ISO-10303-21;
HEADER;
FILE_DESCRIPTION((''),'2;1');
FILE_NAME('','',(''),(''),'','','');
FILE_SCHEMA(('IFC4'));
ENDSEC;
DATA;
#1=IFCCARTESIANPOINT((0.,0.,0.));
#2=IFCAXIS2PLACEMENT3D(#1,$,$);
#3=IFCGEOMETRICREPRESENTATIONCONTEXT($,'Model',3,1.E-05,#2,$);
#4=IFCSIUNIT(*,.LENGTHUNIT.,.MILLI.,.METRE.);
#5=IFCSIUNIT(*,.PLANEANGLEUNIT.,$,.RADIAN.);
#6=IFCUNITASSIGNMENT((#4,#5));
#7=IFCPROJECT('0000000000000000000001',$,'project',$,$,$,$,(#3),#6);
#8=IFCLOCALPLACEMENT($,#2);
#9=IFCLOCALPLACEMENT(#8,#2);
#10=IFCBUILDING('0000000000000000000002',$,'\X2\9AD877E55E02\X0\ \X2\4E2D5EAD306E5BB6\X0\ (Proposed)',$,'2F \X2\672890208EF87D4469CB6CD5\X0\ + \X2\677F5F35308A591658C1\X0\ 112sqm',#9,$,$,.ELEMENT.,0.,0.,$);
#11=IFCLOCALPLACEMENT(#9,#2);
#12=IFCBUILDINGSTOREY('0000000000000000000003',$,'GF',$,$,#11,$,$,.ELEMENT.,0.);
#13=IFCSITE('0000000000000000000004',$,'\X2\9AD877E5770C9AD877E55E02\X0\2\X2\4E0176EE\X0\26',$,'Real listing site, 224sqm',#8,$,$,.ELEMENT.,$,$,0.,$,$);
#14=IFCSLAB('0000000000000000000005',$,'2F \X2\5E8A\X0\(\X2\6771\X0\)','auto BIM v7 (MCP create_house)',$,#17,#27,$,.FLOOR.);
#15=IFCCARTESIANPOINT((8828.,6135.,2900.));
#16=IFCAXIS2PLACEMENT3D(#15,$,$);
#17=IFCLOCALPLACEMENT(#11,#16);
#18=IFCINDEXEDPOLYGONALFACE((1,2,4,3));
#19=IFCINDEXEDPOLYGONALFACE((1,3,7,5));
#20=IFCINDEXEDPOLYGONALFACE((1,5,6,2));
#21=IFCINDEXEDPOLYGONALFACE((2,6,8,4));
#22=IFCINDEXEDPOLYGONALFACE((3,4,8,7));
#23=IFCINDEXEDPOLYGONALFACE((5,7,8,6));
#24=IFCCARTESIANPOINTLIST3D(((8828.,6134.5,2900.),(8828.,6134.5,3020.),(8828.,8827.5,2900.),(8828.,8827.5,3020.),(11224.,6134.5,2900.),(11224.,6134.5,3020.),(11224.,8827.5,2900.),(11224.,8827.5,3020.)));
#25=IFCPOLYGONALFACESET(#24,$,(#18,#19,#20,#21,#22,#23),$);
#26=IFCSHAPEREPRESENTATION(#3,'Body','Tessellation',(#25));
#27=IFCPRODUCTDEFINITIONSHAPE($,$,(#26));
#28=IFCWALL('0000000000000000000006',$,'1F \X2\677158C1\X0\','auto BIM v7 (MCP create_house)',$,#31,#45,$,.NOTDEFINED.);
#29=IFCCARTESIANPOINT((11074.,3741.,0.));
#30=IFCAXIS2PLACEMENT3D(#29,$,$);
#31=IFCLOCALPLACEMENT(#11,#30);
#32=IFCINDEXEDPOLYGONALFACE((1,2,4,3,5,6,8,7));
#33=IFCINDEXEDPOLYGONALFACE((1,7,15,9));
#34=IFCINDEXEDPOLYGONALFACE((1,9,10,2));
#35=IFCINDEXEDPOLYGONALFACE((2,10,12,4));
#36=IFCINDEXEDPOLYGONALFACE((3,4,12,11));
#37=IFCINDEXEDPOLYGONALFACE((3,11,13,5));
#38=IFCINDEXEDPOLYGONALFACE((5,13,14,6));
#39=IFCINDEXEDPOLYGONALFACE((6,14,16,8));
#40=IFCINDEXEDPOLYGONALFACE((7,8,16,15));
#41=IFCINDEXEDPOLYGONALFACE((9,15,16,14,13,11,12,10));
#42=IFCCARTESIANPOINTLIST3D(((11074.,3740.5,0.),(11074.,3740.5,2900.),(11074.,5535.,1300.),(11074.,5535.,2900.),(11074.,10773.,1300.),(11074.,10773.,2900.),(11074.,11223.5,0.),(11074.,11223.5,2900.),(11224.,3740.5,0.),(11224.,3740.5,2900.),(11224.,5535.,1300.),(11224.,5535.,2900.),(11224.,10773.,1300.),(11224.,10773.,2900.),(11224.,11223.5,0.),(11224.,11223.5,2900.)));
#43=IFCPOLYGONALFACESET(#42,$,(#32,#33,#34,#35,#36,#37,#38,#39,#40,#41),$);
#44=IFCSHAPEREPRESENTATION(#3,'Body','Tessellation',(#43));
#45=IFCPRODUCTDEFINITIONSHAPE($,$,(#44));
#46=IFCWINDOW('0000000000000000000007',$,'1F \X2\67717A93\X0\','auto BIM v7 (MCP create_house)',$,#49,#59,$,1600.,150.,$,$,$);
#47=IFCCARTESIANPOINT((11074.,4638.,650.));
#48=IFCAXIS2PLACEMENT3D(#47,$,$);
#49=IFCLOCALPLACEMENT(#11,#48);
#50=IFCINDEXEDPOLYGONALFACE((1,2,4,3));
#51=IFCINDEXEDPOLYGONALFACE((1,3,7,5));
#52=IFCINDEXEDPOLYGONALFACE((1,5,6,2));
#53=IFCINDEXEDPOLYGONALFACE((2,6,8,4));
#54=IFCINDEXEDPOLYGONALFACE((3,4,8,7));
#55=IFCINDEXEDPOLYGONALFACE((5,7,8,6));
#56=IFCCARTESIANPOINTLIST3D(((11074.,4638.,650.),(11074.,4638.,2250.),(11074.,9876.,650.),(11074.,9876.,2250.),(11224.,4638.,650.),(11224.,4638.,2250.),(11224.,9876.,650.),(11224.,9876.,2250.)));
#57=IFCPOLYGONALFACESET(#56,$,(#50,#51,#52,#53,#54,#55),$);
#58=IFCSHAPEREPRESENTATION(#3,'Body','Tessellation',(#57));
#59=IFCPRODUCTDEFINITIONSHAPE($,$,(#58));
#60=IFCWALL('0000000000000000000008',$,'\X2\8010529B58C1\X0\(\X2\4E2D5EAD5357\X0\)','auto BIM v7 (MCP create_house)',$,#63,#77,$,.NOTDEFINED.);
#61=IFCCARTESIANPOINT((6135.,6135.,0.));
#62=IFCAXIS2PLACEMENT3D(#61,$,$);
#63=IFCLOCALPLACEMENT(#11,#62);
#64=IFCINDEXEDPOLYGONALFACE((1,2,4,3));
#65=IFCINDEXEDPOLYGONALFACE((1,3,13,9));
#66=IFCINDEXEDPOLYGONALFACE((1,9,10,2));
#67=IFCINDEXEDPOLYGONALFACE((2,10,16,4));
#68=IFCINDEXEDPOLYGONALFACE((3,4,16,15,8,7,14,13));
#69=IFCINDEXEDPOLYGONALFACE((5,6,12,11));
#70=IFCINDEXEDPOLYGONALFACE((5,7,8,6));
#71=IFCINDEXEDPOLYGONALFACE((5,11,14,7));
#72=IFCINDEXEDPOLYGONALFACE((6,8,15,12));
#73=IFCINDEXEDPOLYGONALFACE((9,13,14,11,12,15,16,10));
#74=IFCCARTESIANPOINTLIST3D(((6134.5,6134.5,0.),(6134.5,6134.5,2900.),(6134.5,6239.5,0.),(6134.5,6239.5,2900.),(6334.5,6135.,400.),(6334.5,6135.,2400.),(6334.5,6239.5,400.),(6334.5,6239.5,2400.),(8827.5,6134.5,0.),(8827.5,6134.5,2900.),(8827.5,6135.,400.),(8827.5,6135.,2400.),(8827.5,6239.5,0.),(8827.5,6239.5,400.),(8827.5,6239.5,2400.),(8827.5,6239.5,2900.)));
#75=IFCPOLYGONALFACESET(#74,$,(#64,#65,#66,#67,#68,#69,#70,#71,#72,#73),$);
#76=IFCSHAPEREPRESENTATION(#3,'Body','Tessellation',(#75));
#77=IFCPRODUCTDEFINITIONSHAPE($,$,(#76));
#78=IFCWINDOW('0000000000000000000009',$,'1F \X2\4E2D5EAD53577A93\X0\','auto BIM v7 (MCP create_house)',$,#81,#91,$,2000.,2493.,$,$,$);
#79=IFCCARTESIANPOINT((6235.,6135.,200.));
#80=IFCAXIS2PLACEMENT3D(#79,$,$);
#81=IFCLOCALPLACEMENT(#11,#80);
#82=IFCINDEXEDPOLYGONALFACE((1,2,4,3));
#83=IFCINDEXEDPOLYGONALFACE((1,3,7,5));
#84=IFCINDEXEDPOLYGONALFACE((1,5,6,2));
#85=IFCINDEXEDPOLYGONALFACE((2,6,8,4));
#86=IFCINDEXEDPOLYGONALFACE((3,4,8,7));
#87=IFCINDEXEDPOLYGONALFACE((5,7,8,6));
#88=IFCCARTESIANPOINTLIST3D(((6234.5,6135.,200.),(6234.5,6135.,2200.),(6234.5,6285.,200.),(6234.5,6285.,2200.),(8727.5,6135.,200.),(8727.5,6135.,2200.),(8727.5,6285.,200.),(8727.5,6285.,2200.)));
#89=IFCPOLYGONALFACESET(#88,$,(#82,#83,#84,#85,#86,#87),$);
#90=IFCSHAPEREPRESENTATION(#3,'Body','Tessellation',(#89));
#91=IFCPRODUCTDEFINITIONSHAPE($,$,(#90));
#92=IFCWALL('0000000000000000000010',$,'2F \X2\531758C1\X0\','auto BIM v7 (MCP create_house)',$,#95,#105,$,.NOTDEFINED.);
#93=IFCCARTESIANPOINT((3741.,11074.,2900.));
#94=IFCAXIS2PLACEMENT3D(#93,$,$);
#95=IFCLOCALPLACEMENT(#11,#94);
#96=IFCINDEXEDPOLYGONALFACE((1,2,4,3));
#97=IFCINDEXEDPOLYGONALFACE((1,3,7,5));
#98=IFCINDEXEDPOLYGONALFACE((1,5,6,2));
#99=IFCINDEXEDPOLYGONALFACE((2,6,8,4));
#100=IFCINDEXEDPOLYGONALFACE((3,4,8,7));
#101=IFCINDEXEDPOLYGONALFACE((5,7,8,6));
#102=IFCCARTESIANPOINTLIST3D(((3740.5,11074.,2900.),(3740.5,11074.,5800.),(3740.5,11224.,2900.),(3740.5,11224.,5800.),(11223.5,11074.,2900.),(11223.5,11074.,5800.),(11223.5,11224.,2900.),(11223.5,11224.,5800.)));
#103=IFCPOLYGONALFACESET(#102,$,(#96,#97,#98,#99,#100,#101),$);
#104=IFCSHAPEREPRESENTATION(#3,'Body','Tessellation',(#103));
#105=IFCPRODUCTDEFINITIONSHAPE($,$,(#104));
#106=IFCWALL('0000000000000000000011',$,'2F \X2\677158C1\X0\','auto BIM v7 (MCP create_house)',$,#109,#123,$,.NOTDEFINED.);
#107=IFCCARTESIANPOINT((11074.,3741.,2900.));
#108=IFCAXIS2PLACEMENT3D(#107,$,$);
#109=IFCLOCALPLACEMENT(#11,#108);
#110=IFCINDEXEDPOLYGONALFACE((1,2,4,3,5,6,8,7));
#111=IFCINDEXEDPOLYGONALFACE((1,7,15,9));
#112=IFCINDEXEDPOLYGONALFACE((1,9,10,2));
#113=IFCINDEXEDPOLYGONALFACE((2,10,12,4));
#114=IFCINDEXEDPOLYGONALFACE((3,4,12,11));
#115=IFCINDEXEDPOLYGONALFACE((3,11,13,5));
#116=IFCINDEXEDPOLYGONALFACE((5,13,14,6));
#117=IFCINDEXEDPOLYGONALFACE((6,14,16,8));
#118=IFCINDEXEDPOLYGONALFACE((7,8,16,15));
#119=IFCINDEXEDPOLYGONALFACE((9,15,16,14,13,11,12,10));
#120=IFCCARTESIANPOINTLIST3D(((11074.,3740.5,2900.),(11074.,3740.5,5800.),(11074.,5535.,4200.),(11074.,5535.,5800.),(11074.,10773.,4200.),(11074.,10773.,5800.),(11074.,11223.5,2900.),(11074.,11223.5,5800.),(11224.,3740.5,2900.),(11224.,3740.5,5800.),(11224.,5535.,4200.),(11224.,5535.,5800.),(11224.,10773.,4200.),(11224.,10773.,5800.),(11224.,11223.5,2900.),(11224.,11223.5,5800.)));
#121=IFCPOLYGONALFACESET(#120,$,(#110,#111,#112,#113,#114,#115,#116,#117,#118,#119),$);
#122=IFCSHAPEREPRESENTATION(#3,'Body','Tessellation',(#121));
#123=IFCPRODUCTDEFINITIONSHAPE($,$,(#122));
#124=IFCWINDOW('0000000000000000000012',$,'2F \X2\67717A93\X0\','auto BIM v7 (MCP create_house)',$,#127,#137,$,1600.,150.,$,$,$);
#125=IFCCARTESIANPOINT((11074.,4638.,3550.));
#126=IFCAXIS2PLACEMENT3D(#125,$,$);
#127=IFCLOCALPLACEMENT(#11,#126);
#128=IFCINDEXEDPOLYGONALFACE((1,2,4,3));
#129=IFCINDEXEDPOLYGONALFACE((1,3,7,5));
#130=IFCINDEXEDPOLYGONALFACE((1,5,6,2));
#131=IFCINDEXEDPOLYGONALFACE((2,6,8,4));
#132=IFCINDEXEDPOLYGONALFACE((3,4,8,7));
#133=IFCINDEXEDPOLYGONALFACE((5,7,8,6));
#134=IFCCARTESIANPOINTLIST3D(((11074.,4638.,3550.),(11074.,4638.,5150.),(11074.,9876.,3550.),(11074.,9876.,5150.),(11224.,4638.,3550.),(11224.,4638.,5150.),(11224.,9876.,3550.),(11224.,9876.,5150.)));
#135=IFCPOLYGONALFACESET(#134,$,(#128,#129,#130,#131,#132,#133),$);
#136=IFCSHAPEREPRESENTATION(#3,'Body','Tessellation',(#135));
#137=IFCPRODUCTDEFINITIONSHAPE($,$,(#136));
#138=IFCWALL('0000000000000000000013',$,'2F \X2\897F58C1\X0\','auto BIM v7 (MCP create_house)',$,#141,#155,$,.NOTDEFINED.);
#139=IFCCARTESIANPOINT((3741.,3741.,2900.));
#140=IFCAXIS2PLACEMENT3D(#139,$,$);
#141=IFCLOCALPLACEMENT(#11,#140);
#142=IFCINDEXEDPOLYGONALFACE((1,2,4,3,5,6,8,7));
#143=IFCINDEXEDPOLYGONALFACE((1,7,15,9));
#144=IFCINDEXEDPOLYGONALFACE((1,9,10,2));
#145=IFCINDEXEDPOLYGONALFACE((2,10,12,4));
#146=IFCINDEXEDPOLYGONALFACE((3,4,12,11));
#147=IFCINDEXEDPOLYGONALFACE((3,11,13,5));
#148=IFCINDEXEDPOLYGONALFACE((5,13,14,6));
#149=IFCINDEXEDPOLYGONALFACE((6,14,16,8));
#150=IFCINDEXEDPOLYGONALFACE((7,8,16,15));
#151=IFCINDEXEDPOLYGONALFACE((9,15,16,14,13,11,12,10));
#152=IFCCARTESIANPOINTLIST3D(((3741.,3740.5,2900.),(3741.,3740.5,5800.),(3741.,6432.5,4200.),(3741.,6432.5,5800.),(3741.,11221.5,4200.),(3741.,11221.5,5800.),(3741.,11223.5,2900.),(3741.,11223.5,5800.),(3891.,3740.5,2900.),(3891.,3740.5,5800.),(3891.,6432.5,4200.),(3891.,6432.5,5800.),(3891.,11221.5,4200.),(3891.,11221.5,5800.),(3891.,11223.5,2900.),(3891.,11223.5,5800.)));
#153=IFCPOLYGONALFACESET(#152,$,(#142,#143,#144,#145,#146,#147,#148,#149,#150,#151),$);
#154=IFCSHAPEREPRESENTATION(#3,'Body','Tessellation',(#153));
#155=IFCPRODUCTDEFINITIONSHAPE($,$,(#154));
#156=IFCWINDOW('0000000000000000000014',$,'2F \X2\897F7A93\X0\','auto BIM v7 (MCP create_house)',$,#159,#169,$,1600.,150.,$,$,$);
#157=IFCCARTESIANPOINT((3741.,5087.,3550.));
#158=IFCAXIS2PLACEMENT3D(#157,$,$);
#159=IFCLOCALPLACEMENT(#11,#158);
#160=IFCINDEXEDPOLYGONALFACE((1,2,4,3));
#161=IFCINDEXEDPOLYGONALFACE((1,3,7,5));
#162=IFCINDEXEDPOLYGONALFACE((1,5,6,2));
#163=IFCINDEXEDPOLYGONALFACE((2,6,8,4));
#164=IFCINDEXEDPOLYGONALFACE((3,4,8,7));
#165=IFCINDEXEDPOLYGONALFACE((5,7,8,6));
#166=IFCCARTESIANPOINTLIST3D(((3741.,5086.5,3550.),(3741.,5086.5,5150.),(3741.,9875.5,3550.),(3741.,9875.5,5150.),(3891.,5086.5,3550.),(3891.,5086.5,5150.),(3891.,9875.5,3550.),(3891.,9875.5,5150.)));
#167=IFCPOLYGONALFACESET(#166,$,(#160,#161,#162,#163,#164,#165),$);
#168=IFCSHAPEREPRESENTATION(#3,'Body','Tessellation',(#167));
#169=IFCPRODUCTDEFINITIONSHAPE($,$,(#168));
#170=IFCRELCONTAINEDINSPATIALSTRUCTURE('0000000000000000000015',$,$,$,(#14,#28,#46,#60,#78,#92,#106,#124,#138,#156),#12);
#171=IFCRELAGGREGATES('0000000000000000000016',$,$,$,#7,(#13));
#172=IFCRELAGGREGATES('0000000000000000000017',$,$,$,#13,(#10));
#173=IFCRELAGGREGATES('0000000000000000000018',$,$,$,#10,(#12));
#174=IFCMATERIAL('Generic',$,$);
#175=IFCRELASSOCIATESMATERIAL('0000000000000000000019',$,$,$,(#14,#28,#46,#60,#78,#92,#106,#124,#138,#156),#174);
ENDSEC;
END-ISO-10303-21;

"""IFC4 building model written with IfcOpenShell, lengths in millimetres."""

from ifc_helpers import new_model, si_unit, frame, frame_2d, origin, place, context, project, spatial, rectangle, extrude, material, element, fill, save


model = new_model("IFC4")

# Units and contexts
model_context = context("Model", 3, precision=1e-05, world=origin())
ifc_project = project(units=[si_unit("LENGTHUNIT", "METRE", prefix="MILLI"), si_unit("PLANEANGLEUNIT", "RADIAN")], contexts=[model_context])

# Site, building, storey
site_placement = place(None, origin())
site = spatial("IfcSite", under=ifc_project, at=site_placement, Name="高知県高知市2丁目26", ObjectType="Real listing site, 224sqm", CompositionType="ELEMENT", RefElevation=0.0)
building_placement = place(site_placement, origin())
building = spatial("IfcBuilding", under=site, at=building_placement, Name="高知市 中庭の家 (Proposed)", ObjectType="2F 木造軸組構法 + 板張り外壁 112sqm", CompositionType="ELEMENT", ElevationOfRefHeight=0.0, ElevationOfTerrain=0.0)
storey_placement = place(building_placement, origin())
storey = spatial("IfcBuildingStorey", under=building, at=storey_placement, Name="GF", CompositionType="ELEMENT", Elevation=0.0)

# Slab
ifc_material = material(Name="Generic")
slab_1_placement = place(storey_placement, frame((8828.0, 6135.0, 2900.0)))
element("IfcSlab", 1, at=slab_1_placement, inside=storey, material=ifc_material, Name="2F 床(東)", Description="auto BIM v7 (MCP create_house)", PredefinedType="FLOOR", context=model_context, shape_type="SweptSolid", body=[
    extrude(rectangle(XDim=2396.0, YDim=2693.0, at=frame_2d((1198.0, 1346.0))), frame((8828.0, 6135.0, 2900.0)), (0.0, 0.0, 1.0), 120.0),
])

# Walls, openings, windows
wall_1_placement = place(storey_placement, frame((11074.0, 3741.0, 0.0)))
wall_1 = element("IfcWall", 2, at=wall_1_placement, inside=storey, material=ifc_material, Name="1F 東壁", Description="auto BIM v7 (MCP create_house)", PredefinedType="NOTDEFINED", context=model_context, shape_type="SweptSolid", body=[
    extrude(rectangle(XDim=150.0, YDim=7483.0, at=frame_2d((75.0, 3741.0))), frame((11074.0, 3741.0, 0.0)), (0.0, 0.0, 1.0), 2900.0),
])
opening_1_placement = place(storey_placement, frame((11074.0, 4638.0, 650.0)))
opening_1 = element("IfcOpeningElement", 3, at=opening_1_placement, cuts=wall_1, PredefinedType="NOTDEFINED", context=model_context, shape_type="SweptSolid", body=[
    extrude(rectangle(XDim=150.0, YDim=5238.0, at=frame_2d((75.0, 2619.0))), frame((11074.0, 4638.0, 650.0)), (0.0, 0.0, 1.0), 1600.0),
])
window_1_placement = place(storey_placement, frame((11074.0, 4638.0, 650.0)))
window_1 = element("IfcWindow", 4, at=window_1_placement, inside=storey, material=ifc_material, Name="1F 東窓", Description="auto BIM v7 (MCP create_house)", OverallHeight=1600.0, OverallWidth=150.0, context=model_context, shape_type="SweptSolid", body=[
    extrude(rectangle(XDim=150.0, YDim=5238.0, at=frame_2d((75.0, 2619.0))), frame((11074.0, 4638.0, 650.0)), (0.0, 0.0, 1.0), 1600.0),
])
fill(opening_1, window_1)
wall_2_placement = place(storey_placement, frame((6135.0, 6135.0, 0.0)))
wall_2 = element("IfcWall", 5, at=wall_2_placement, inside=storey, material=ifc_material, Name="耐力壁(中庭南)", Description="auto BIM v7 (MCP create_house)", PredefinedType="NOTDEFINED", context=model_context, shape_type="SweptSolid", body=[
    extrude(rectangle(XDim=2693.0, YDim=105.0, at=frame_2d((1346.0, 52.0))), frame((6135.0, 6135.0, 0.0)), (0.0, 0.0, 1.0), 2900.0),
])
opening_2_placement = place(storey_placement, frame((6235.0, 6135.0, 200.0)))
opening_2 = element("IfcOpeningElement", 6, at=opening_2_placement, cuts=wall_2, PredefinedType="NOTDEFINED", context=model_context, shape_type="SweptSolid", body=[
    extrude(rectangle(XDim=2493.0, YDim=150.0, at=frame_2d((1246.0, 75.0))), frame((6235.0, 6135.0, 200.0)), (0.0, 0.0, 1.0), 2000.0),
])
window_2_placement = place(storey_placement, frame((6235.0, 6135.0, 200.0)))
window_2 = element("IfcWindow", 7, at=window_2_placement, inside=storey, material=ifc_material, Name="1F 中庭南窓", Description="auto BIM v7 (MCP create_house)", OverallHeight=2000.0, OverallWidth=2493.0, context=model_context, shape_type="SweptSolid", body=[
    extrude(rectangle(XDim=2493.0, YDim=150.0, at=frame_2d((1246.0, 75.0))), frame((6235.0, 6135.0, 200.0)), (0.0, 0.0, 1.0), 2000.0),
])
fill(opening_2, window_2)

# Wall
wall_3_placement = place(storey_placement, frame((3741.0, 11074.0, 2900.0)))
element("IfcWall", 8, at=wall_3_placement, inside=storey, material=ifc_material, Name="2F 北壁", Description="auto BIM v7 (MCP create_house)", PredefinedType="NOTDEFINED", context=model_context, shape_type="SweptSolid", body=[
    extrude(rectangle(XDim=7483.0, YDim=150.0, at=frame_2d((3741.0, 75.0))), frame((3741.0, 11074.0, 2900.0)), (0.0, 0.0, 1.0), 2900.0),
])

# Walls, openings, windows
wall_4_placement = place(storey_placement, frame((11074.0, 3741.0, 2900.0)))
wall_4 = element("IfcWall", 9, at=wall_4_placement, inside=storey, material=ifc_material, Name="2F 東壁", Description="auto BIM v7 (MCP create_house)", PredefinedType="NOTDEFINED", context=model_context, shape_type="SweptSolid", body=[
    extrude(rectangle(XDim=150.0, YDim=7483.0, at=frame_2d((75.0, 3741.0))), frame((11074.0, 3741.0, 2900.0)), (0.0, 0.0, 1.0), 2900.0),
])
opening_3_placement = place(storey_placement, frame((11074.0, 4638.0, 3550.0)))
opening_3 = element("IfcOpeningElement", 10, at=opening_3_placement, cuts=wall_4, PredefinedType="NOTDEFINED", context=model_context, shape_type="SweptSolid", body=[
    extrude(rectangle(XDim=150.0, YDim=5238.0, at=frame_2d((75.0, 2619.0))), frame((11074.0, 4638.0, 3550.0)), (0.0, 0.0, 1.0), 1600.0),
])
window_3_placement = place(storey_placement, frame((11074.0, 4638.0, 3550.0)))
window_3 = element("IfcWindow", 11, at=window_3_placement, inside=storey, material=ifc_material, Name="2F 東窓", Description="auto BIM v7 (MCP create_house)", OverallHeight=1600.0, OverallWidth=150.0, context=model_context, shape_type="SweptSolid", body=[
    extrude(rectangle(XDim=150.0, YDim=5238.0, at=frame_2d((75.0, 2619.0))), frame((11074.0, 4638.0, 3550.0)), (0.0, 0.0, 1.0), 1600.0),
])
fill(opening_3, window_3)
wall_5_placement = place(storey_placement, frame((3741.0, 3741.0, 2900.0)))
wall_5 = element("IfcWall", 12, at=wall_5_placement, inside=storey, material=ifc_material, Name="2F 西壁", Description="auto BIM v7 (MCP create_house)", PredefinedType="NOTDEFINED", context=model_context, shape_type="SweptSolid", body=[
    extrude(rectangle(XDim=150.0, YDim=7483.0, at=frame_2d((75.0, 3741.0))), frame((3741.0, 3741.0, 2900.0)), (0.0, 0.0, 1.0), 2900.0),
])
opening_4_placement = place(storey_placement, frame((3741.0, 5087.0, 3550.0)))
opening_4 = element("IfcOpeningElement", 13, at=opening_4_placement, cuts=wall_5, PredefinedType="NOTDEFINED", context=model_context, shape_type="SweptSolid", body=[
    extrude(rectangle(XDim=150.0, YDim=4789.0, at=frame_2d((75.0, 2394.0))), frame((3741.0, 5087.0, 3550.0)), (0.0, 0.0, 1.0), 1600.0),
])
window_4_placement = place(storey_placement, frame((3741.0, 5087.0, 3550.0)))
window_4 = element("IfcWindow", 14, at=window_4_placement, inside=storey, material=ifc_material, Name="2F 西窓", Description="auto BIM v7 (MCP create_house)", OverallHeight=1600.0, OverallWidth=150.0, context=model_context, shape_type="SweptSolid", body=[
    extrude(rectangle(XDim=150.0, YDim=4789.0, at=frame_2d((75.0, 2394.0))), frame((3741.0, 5087.0, 3550.0)), (0.0, 0.0, 1.0), 1600.0),
])
fill(opening_4, window_4)

save(model, "model.ifc")
